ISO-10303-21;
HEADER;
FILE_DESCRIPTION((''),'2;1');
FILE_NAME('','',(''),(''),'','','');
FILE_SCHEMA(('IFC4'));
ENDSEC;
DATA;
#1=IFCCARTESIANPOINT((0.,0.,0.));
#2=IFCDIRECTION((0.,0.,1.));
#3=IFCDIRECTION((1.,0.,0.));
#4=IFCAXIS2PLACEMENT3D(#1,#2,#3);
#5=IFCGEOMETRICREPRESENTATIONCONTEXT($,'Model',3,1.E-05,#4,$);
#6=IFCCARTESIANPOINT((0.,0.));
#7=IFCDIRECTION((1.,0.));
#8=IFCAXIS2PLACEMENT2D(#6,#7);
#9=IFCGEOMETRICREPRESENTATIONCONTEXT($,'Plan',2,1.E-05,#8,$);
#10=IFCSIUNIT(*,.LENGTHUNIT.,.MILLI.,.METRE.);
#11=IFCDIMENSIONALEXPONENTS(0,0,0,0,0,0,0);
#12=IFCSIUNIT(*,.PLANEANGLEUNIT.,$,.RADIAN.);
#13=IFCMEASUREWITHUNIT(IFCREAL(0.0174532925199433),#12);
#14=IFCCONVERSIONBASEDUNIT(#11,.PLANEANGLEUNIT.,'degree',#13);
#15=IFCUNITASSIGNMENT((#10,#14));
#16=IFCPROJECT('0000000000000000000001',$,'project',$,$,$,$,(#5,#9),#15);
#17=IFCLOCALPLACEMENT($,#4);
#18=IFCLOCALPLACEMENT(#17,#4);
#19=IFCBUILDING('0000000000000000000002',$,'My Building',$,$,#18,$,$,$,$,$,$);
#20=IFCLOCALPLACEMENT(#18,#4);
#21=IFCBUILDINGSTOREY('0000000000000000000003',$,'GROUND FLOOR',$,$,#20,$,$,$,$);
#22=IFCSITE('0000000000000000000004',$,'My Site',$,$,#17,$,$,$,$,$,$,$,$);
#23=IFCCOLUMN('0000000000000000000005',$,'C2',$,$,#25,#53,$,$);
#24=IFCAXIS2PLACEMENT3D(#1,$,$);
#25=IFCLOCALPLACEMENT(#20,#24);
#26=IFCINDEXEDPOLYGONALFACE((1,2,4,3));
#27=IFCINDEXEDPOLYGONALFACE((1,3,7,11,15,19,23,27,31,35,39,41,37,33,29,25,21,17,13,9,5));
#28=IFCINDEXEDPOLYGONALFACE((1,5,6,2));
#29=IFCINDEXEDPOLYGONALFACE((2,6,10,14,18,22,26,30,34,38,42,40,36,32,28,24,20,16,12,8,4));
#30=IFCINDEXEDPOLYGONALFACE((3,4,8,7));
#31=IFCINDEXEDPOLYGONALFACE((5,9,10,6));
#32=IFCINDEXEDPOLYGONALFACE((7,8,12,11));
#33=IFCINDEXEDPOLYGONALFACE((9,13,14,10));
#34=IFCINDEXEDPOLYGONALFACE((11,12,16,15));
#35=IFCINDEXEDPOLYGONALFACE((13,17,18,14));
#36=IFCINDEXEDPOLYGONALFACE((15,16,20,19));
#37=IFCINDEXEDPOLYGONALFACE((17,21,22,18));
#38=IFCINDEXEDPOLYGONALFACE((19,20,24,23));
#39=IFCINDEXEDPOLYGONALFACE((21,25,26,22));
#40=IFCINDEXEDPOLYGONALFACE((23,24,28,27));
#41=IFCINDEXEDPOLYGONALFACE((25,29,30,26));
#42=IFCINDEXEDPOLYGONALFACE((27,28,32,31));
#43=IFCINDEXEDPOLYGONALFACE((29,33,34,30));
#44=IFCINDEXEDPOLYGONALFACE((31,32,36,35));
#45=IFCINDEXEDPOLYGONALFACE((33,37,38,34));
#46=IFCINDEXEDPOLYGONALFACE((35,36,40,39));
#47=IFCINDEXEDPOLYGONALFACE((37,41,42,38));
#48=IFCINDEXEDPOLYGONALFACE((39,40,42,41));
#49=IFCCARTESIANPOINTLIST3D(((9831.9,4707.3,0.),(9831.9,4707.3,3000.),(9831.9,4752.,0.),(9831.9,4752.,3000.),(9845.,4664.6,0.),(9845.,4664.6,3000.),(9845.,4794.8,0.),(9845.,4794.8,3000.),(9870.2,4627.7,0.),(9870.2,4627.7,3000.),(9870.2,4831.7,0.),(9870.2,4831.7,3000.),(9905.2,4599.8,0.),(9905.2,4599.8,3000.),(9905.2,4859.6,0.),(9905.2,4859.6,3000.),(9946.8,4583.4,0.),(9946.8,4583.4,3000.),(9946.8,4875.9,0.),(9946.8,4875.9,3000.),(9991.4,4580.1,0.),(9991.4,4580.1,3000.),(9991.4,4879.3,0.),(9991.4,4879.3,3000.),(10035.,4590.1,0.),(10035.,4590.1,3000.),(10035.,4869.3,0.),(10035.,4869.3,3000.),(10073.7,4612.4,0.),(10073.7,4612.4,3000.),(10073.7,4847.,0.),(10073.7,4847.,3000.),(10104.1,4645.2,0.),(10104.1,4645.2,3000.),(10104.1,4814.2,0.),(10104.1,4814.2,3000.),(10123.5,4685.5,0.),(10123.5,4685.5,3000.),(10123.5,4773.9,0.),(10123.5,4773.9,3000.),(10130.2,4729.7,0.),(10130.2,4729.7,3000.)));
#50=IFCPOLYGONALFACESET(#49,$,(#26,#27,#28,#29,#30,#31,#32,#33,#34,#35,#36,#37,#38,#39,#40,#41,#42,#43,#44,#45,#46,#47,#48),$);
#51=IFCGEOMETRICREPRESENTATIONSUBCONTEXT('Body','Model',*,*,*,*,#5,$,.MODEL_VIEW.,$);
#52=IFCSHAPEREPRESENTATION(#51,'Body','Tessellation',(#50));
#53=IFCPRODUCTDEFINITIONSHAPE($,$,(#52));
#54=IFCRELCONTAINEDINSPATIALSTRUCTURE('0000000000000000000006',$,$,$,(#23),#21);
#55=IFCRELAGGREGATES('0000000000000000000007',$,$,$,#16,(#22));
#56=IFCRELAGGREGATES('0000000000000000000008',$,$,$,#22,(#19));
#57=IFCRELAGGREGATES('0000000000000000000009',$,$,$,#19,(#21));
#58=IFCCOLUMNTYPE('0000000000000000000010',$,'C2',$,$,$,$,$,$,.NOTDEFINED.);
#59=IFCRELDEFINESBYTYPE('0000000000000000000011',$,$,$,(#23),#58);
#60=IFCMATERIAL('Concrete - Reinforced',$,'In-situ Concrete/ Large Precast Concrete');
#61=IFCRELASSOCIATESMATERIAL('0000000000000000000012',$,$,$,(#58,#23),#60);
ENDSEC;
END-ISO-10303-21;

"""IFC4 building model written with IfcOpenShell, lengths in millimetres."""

from ifc_helpers import new_model, entity, si_unit, converted_unit, frame, origin_with_axes, origin_2d_with_axis, place, context, subcontext, project, spatial, circle, extrude, material, material_profile, profile_set, profile_usage, type_object, element, save


model = new_model("IFC4")

# Units and contexts
model_context = context("Model", 3, precision=1e-05, world=origin_with_axes())
plan_context = context("Plan", 2, precision=1e-05, world=origin_2d_with_axis())
body_context_1 = subcontext(model_context, "Body", "Model", "MODEL_VIEW")
ifc_project = project(units=[si_unit("LENGTHUNIT", "METRE", prefix="MILLI"), converted_unit("PLANEANGLEUNIT", "degree", entity("IfcReal", 0.0174532925199433), si_unit("PLANEANGLEUNIT", "RADIAN"), dimensions=[0, 0, 0, 0, 0, 0, 0])], contexts=[model_context, plan_context])

# Site, building, storey
site_placement = place(None, origin_with_axes())
site = spatial("IfcSite", under=ifc_project, at=site_placement, Name="My Site")
building_placement = place(site_placement, origin_with_axes())
building = spatial("IfcBuilding", under=site, at=building_placement, Name="My Building")
storey_placement = place(building_placement, origin_with_axes())
storey = spatial("IfcBuildingStorey", under=building, at=storey_placement, Name="GROUND FLOOR")

# Column
ifc_material_1 = material(Name="Concrete - Reinforced", Category="In-situ Concrete/ Large Precast Concrete")
ifc_material_profile = material_profile(ifc_material_1, circle(Radius=150.0), Name="150mm  Radius", Category="LoadBearing", Priority=1)
ifc_profile_set = profile_set([ifc_material_profile], Name="concreteColumn")
ifc_profile_usage = profile_usage(ifc_profile_set)
column_type = type_object("IfcColumnType", Name="C2", PredefinedType="NOTDEFINED", material=ifc_profile_set)
column_placement = place(storey_placement, frame((9980.2, 4729.7, 0.0), z_axis=(0.0, 0.0, 1.0), x_axis=(1.0, 0.0, 0.0)))
element("IfcColumn", 1, at=column_placement, inside=storey, type_object=column_type, material=ifc_profile_usage, Name="C2", context=body_context_1, shape_type="SweptSolid", body=[
    extrude(circle(Radius=150.0), origin_with_axes(), (0.0, 0.0, 1.0), 3000.0),
])

save(model, "model.ifc")
